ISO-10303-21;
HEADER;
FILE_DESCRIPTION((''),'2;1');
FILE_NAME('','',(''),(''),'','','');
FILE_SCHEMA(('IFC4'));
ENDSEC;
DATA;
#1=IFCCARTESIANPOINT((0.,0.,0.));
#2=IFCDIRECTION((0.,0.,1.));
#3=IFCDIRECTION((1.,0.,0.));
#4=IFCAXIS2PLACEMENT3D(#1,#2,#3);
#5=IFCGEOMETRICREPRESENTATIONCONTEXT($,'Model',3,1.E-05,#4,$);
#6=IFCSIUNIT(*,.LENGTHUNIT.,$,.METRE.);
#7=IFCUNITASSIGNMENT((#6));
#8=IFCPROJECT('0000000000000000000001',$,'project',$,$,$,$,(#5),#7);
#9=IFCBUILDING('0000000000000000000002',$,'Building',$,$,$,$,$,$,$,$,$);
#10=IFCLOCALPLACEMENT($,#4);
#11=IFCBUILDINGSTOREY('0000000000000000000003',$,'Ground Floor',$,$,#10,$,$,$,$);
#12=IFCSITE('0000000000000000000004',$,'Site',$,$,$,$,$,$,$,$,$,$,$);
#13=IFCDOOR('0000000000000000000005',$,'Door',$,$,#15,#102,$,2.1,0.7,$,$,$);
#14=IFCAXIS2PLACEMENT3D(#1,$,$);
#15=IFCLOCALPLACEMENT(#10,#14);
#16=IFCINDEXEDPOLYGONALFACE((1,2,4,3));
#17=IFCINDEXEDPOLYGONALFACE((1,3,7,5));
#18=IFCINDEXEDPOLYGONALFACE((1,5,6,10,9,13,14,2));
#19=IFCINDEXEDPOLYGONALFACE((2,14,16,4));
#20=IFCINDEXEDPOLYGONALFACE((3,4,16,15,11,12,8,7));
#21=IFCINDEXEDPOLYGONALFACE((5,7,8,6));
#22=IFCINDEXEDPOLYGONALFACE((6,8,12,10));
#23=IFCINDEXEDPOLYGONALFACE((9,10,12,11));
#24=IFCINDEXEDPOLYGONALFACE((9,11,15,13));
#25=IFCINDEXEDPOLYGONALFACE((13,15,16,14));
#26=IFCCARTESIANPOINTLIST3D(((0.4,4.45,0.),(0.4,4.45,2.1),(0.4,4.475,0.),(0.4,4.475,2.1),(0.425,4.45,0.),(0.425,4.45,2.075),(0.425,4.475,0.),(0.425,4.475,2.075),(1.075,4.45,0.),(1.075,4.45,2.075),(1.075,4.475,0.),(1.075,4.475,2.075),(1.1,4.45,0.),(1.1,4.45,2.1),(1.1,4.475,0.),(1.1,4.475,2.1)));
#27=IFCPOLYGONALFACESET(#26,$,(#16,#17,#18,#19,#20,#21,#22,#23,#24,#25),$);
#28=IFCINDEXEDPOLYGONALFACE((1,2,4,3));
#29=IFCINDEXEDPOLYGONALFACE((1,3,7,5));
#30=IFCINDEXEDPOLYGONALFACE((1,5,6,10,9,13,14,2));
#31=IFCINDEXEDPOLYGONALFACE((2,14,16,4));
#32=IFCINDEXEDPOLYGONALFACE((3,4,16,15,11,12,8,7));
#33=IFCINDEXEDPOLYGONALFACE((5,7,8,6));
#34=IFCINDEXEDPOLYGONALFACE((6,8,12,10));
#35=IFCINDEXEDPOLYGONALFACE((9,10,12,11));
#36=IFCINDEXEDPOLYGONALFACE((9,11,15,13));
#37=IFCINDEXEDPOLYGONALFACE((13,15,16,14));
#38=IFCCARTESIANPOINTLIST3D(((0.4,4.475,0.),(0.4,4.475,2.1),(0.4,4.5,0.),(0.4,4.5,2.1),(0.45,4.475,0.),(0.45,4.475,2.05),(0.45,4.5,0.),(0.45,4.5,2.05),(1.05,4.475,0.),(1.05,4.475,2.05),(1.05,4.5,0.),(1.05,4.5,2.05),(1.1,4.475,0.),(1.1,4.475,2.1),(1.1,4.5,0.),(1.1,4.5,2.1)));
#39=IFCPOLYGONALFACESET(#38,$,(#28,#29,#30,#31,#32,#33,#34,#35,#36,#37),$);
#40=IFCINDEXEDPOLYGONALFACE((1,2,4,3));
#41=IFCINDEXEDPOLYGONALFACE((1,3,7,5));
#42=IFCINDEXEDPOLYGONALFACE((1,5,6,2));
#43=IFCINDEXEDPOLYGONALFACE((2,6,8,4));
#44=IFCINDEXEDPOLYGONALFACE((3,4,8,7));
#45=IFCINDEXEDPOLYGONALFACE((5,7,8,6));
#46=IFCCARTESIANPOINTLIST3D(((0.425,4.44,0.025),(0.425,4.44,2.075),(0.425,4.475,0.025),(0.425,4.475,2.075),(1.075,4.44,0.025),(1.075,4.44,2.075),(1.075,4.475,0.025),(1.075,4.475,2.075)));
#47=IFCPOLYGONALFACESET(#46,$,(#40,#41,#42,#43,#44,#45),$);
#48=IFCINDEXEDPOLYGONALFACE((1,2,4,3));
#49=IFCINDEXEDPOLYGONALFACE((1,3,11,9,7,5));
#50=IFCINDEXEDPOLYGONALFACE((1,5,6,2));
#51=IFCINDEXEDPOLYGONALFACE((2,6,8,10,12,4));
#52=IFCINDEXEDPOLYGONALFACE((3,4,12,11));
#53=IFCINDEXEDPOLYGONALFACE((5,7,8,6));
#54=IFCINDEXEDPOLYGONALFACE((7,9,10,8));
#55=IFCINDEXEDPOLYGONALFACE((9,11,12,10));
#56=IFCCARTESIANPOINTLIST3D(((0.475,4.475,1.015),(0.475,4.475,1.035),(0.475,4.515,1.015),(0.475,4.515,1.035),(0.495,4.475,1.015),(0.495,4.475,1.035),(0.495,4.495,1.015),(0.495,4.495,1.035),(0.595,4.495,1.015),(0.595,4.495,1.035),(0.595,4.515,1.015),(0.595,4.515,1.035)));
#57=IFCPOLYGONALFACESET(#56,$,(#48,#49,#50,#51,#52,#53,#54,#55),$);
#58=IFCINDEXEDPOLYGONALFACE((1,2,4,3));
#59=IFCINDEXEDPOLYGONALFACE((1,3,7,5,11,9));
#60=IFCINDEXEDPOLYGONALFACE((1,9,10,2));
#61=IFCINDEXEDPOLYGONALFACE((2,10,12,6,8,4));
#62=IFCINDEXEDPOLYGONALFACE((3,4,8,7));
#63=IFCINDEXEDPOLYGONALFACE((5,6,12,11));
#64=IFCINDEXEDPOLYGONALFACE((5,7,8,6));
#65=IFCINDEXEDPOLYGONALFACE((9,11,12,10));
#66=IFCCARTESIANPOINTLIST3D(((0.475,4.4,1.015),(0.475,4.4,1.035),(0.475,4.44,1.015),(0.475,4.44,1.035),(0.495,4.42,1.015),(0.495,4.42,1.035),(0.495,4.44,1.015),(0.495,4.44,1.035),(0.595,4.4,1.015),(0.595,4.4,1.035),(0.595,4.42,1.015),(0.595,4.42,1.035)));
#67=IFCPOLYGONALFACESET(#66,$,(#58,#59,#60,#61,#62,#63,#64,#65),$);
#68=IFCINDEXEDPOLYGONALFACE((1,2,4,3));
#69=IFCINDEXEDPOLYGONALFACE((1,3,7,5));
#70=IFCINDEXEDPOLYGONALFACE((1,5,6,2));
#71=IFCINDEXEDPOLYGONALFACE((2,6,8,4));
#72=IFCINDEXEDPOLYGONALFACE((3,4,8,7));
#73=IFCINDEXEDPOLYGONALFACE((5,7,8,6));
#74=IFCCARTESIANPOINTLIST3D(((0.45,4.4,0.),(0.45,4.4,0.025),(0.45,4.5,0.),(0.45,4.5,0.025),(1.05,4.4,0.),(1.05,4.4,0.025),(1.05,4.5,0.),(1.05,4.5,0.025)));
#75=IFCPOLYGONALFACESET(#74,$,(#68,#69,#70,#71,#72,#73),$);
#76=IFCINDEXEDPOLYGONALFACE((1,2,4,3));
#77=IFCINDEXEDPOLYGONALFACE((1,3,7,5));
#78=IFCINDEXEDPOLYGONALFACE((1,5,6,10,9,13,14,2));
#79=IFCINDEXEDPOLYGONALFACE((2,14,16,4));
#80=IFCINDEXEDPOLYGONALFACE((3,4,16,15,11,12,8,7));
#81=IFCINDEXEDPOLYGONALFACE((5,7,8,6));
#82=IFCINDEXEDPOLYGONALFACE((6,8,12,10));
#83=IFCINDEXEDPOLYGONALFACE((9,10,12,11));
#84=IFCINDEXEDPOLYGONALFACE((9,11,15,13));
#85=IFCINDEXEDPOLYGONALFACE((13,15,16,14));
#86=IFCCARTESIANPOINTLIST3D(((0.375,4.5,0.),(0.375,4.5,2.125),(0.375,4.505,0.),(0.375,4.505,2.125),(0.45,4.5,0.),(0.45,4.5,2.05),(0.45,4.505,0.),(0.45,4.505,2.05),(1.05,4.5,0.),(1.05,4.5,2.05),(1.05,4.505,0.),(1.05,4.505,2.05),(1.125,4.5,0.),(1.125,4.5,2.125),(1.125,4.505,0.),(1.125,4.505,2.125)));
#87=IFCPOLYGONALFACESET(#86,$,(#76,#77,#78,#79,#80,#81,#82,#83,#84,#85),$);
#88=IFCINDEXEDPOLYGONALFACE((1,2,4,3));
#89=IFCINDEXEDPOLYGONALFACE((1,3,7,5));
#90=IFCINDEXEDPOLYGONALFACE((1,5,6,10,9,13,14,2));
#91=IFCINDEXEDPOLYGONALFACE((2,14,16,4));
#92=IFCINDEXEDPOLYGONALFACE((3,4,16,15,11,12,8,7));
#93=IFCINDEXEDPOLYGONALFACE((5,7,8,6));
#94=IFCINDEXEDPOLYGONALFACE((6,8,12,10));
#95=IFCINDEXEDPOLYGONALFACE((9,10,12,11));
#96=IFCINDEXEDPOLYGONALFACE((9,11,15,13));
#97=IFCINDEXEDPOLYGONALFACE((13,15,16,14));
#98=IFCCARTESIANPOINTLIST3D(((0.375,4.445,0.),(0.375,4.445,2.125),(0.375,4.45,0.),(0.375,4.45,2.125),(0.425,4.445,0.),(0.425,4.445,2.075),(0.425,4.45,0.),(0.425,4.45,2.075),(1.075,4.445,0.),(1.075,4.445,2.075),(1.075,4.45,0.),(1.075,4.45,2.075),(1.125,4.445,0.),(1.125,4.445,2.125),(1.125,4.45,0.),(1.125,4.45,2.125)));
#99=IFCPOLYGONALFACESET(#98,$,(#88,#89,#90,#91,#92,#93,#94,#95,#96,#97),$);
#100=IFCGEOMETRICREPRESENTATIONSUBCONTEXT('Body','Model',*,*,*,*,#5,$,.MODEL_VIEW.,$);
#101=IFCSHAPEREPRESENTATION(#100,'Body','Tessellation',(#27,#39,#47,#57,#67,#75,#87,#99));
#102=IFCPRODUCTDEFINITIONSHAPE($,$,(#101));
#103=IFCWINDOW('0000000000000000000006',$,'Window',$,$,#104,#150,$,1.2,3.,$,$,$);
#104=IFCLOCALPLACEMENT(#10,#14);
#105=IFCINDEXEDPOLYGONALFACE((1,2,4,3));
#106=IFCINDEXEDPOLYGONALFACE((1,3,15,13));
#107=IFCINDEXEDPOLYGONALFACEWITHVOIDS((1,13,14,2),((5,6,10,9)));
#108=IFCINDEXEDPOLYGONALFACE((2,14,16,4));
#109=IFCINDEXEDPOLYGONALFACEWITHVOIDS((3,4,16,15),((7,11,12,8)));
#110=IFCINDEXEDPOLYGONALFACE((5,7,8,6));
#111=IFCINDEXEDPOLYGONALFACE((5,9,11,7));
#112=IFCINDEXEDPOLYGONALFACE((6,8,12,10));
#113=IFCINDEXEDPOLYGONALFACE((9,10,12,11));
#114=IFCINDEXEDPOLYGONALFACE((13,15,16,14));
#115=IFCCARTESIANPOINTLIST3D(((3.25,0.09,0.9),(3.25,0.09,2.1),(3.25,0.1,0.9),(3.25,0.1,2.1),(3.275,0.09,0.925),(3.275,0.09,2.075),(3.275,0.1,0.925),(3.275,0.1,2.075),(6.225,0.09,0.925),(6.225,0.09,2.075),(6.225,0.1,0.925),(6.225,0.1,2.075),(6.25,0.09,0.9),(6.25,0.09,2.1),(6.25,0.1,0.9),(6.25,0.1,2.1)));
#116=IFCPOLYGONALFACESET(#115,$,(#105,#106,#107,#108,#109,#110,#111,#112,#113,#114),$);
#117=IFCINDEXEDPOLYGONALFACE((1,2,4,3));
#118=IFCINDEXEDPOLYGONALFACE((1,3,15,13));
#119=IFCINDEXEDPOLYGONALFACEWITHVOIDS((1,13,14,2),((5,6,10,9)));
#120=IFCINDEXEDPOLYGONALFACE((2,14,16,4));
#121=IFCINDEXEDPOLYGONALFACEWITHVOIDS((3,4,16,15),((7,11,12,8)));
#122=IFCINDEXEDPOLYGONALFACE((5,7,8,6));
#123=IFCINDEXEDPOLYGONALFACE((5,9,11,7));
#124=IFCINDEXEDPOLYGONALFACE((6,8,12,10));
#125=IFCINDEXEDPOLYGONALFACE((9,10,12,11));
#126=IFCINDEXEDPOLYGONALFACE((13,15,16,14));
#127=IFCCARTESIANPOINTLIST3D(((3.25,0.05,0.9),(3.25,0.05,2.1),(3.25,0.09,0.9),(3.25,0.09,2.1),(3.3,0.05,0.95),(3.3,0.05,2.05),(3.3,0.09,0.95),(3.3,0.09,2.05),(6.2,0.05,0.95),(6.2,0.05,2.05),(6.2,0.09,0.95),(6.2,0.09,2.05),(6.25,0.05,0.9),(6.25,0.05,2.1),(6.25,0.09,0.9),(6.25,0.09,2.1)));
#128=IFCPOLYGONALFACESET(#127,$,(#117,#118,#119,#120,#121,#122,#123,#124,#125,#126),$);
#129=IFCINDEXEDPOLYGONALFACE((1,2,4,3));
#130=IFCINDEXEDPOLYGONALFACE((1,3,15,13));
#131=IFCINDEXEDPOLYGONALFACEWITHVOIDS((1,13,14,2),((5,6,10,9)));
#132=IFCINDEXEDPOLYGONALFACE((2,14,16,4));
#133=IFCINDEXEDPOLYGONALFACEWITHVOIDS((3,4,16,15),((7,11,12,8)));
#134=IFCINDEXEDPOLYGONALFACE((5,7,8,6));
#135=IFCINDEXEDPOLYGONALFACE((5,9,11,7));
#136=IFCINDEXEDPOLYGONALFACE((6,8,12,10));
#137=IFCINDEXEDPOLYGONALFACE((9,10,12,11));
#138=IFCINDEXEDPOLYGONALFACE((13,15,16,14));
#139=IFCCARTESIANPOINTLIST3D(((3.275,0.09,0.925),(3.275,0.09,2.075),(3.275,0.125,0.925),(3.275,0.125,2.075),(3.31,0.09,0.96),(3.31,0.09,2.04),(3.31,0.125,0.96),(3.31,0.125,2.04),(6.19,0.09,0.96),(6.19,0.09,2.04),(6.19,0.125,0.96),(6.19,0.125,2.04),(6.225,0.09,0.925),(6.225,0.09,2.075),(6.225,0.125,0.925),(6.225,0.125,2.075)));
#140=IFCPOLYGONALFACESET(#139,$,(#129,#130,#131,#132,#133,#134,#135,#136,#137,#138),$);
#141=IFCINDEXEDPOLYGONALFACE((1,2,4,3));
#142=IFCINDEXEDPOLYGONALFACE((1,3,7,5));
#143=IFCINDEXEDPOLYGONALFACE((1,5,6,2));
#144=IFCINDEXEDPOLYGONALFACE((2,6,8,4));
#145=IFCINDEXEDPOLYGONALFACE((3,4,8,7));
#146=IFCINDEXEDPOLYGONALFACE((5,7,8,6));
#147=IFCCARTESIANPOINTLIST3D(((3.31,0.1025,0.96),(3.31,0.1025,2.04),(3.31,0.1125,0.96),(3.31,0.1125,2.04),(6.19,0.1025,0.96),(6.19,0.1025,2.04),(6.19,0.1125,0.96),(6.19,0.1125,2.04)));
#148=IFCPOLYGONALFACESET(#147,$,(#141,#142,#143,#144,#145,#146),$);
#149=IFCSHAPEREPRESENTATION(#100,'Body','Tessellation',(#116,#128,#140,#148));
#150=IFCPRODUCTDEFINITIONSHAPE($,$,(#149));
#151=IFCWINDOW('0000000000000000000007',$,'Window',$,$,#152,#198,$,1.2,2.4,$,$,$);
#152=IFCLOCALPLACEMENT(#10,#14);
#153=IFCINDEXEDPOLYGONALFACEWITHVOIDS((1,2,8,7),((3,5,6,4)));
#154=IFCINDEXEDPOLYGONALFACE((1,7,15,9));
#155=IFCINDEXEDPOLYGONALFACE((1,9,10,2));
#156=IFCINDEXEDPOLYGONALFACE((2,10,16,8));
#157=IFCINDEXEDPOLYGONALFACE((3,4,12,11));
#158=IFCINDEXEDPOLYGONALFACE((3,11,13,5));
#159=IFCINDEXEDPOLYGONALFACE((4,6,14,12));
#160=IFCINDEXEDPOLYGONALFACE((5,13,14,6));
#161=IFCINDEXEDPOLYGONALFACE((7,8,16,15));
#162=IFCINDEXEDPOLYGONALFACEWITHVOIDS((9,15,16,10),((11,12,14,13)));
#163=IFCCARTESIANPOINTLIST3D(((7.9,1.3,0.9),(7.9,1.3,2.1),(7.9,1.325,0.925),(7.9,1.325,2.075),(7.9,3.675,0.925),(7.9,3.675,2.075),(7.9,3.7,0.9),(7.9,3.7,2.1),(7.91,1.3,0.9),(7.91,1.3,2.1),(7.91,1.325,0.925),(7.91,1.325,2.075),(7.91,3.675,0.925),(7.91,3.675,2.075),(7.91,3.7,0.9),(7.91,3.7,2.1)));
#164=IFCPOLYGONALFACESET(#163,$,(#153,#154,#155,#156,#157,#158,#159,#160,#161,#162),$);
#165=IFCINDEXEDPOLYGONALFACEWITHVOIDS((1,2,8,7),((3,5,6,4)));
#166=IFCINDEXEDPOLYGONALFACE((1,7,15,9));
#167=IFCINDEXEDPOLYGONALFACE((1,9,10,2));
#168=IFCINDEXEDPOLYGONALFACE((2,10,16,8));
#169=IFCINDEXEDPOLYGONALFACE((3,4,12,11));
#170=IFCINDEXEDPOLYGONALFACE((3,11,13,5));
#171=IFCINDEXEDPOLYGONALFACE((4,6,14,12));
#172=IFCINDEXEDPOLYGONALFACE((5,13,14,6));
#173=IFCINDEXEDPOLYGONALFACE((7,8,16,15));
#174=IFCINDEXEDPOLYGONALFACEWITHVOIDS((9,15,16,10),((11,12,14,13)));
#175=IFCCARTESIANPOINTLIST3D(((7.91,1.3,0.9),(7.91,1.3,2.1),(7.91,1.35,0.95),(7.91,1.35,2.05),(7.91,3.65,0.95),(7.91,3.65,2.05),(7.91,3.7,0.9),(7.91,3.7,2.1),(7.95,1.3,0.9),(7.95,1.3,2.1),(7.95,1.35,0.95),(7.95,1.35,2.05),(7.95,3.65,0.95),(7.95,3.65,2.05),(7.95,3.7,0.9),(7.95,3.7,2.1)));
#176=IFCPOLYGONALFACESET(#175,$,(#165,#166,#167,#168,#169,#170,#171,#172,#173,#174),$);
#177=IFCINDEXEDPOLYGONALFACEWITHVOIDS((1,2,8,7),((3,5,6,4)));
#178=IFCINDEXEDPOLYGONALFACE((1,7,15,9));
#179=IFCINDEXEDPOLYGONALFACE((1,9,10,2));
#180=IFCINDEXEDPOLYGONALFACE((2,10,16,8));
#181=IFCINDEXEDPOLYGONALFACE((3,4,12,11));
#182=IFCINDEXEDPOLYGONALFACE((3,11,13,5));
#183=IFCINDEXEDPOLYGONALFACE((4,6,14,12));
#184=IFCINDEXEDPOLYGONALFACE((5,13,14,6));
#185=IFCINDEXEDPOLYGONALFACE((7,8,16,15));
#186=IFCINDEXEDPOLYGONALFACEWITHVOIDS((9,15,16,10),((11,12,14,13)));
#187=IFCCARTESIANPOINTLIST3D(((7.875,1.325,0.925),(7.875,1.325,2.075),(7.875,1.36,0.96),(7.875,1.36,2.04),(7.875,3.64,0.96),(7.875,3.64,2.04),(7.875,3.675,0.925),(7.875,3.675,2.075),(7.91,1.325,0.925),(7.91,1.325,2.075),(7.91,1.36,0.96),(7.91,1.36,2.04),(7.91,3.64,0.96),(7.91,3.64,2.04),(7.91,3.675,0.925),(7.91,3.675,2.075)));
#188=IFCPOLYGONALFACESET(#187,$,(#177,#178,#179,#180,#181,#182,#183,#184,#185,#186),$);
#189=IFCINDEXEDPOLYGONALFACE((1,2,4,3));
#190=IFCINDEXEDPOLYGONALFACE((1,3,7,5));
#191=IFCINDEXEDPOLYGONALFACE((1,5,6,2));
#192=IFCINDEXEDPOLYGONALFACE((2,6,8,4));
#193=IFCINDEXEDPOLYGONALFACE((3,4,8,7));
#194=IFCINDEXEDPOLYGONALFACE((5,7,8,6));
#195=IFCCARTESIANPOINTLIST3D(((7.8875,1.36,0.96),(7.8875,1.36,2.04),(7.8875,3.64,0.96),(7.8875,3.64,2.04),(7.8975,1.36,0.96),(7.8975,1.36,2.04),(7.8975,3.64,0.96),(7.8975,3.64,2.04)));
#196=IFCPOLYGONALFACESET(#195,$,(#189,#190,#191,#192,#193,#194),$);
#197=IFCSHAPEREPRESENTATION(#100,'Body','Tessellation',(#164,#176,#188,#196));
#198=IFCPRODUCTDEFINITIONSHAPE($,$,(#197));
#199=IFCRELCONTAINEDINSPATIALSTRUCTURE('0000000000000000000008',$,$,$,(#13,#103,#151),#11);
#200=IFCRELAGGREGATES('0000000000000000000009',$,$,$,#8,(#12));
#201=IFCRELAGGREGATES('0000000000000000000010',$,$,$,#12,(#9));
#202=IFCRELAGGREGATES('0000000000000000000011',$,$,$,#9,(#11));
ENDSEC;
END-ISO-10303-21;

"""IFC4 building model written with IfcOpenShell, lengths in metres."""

from ifc_helpers import new_model, si_unit, frame, origin_with_axes, place, context, subcontext, project, spatial, line, indexed_curve, outline, extrude, element, save


model = new_model("IFC4")

# Units and contexts
model_context = context("Model", 3, precision=1e-05, world=origin_with_axes())
body_context = subcontext(model_context, "Body", "Model", "MODEL_VIEW")
ifc_project = project(units=[si_unit("LENGTHUNIT", "METRE")], contexts=[model_context])

# Site, building, storey
site = spatial("IfcSite", under=ifc_project, Name="Site")
building = spatial("IfcBuilding", under=site, Name="Building")
storey_placement = place(None, origin_with_axes())
storey = spatial("IfcBuildingStorey", under=building, at=storey_placement, Name="Ground Floor")

# Door
door_1_placement = place(storey_placement, frame((1.1, 4.5, 0.0), z_axis=(0.0, 0.0, 1.0), x_axis=(-1.0, 0.0, 0.0)))
element("IfcDoor", 1, at=door_1_placement, inside=storey, Name="Door", OverallHeight=2.1, OverallWidth=0.7, context=body_context, shape_type="SweptSolid", body=[
    extrude(outline(indexed_curve([(0.0, 0.0), (0.0, 2.1), (0.7, 2.1), (0.7, 0.0), (0.675, 0.0), (0.675, 2.075), (0.025, 2.075), (0.025, 0.0)], segments=[line(1, 2, 3, 4, 5, 6, 7, 8, 1)])), frame((0.0, 0.025, 0.0), z_axis=(0.0, -1.0, 0.0), x_axis=(1.0, 0.0, 0.0)), (0.0, 0.0, -1.0), 0.025),
    extrude(outline(indexed_curve([(0.0, 0.0), (0.0, 2.1), (0.7, 2.1), (0.7, 0.0), (0.65, 0.0), (0.65, 2.05), (0.05, 2.05), (0.05, 0.0)], segments=[line(1, 2, 3, 4, 5, 6, 7, 8, 1)])), frame((0.0, 0.0, 0.0), z_axis=(0.0, -1.0, 0.0), x_axis=(1.0, 0.0, 0.0)), (0.0, 0.0, -1.0), 0.025),
    extrude(outline(indexed_curve([(0.0, 0.0), (0.65, 0.0), (0.65, 0.035), (0.0, 0.035)], segments=[line(1, 2, 3, 4, 1)])), frame((0.025, 0.025, 0.025), z_axis=(0.0, 0.0, 1.0), x_axis=(1.0, 0.0, 0.0)), (0.0, 0.0, 1.0), 2.05),
    extrude(outline(indexed_curve([(0.0, 0.0), (0.0, -0.04), (-0.12, -0.04), (-0.12, -0.02), (-0.02, -0.02), (-0.02, 0.0)], segments=[line(1, 2, 3, 4, 5, 6, 1)])), frame((0.625, 0.025, 1.015), z_axis=(0.0, 0.0, 1.0), x_axis=(1.0, 0.0, 0.0)), (0.0, 0.0, 1.0), 0.02),
    extrude(outline(indexed_curve([(0.0, 0.0), (0.0, 0.04), (-0.12, 0.04), (-0.12, 0.02), (-0.02, 0.02), (-0.02, 0.0)], segments=[line(1, 2, 3, 4, 5, 6, 1)])), frame((0.625, 0.06, 1.015), z_axis=(0.0, 0.0, 1.0), x_axis=(1.0, 0.0, 0.0)), (0.0, 0.0, 1.0), 0.02),
    extrude(outline(indexed_curve([(0.0, 0.0), (0.6, 0.0), (0.6, 0.1), (0.0, 0.1)], segments=[line(1, 2, 3, 4, 1)])), frame((0.05, 0.0, 0.0), z_axis=(0.0, 0.0, 1.0), x_axis=(1.0, 0.0, 0.0)), (0.0, 0.0, 1.0), 0.025),
    extrude(outline(indexed_curve([(0.0, 0.0), (0.0, 2.125), (0.75, 2.125), (0.75, 0.0), (0.675, 0.0), (0.675, 2.05), (0.075, 2.05), (0.075, 0.0)], segments=[line(1, 2, 3, 4, 5, 6, 7, 8, 1)])), frame((-0.025, -0.005, 0.0), z_axis=(0.0, -1.0, 0.0), x_axis=(1.0, 0.0, 0.0)), (0.0, 0.0, -1.0), 0.005),
    extrude(outline(indexed_curve([(0.0, 0.0), (0.0, 2.125), (0.75, 2.125), (0.75, 0.0), (0.7, 0.0), (0.7, 2.075), (0.05, 2.075), (0.05, 0.0)], segments=[line(1, 2, 3, 4, 5, 6, 7, 8, 1)])), frame((-0.025, 0.05, 0.0), z_axis=(0.0, -1.0, 0.0), x_axis=(1.0, 0.0, 0.0)), (0.0, 0.0, -1.0), 0.005),
])

# Windows
window_1_placement = place(storey_placement, frame((3.25, 0.0, 0.9), z_axis=(0.0, 0.0, 1.0), x_axis=(1.0, 0.0, 0.0)))
element("IfcWindow", 2, at=window_1_placement, inside=storey, Name="Window", OverallHeight=1.2, OverallWidth=3.0, context=body_context, shape_type="SweptSolid", body=[
    extrude(outline(indexed_curve([(0.0, 0.0), (3.0, 0.0), (3.0, 1.2), (0.0, 1.2)], segments=[line(1, 2, 3, 4, 1)]), holes=[indexed_curve([(0.025, 0.025), (2.975, 0.025), (2.975, 1.175), (0.025, 1.175)], segments=[line(1, 2, 3, 4, 1)])]), frame((0.0, 0.09, 0.0), z_axis=(0.0, -1.0, 0.0), x_axis=(1.0, 0.0, 0.0)), (0.0, 0.0, -1.0), 0.01),
    extrude(outline(indexed_curve([(0.0, 0.0), (3.0, 0.0), (3.0, 1.2), (0.0, 1.2)], segments=[line(1, 2, 3, 4, 1)]), holes=[indexed_curve([(0.05, 0.05), (2.95, 0.05), (2.95, 1.15), (0.05, 1.15)], segments=[line(1, 2, 3, 4, 1)])]), frame((0.0, 0.05, 0.0), z_axis=(0.0, -1.0, 0.0), x_axis=(1.0, 0.0, 0.0)), (0.0, 0.0, -1.0), 0.04),
    extrude(outline(indexed_curve([(0.0, 0.0), (2.95, 0.0), (2.95, 1.15), (0.0, 1.15)], segments=[line(1, 2, 3, 4, 1)]), holes=[indexed_curve([(0.035, 0.035), (2.915, 0.035), (2.915, 1.115), (0.035, 1.115)], segments=[line(1, 2, 3, 4, 1)])]), frame((0.025, 0.09, 0.025), z_axis=(0.0, -1.0, 0.0), x_axis=(1.0, 0.0, 0.0)), (0.0, 0.0, -1.0), 0.035),
    extrude(outline(indexed_curve([(0.035, 0.035), (2.915, 0.035), (2.915, 1.115), (0.035, 1.115)], segments=[line(1, 2, 3, 4, 1)])), frame((0.025, 0.1025, 0.025), z_axis=(0.0, -1.0, 0.0), x_axis=(1.0, 0.0, 0.0)), (0.0, 0.0, -1.0), 0.01),
])
window_2_placement = place(storey_placement, frame((8.0, 1.3, 0.9), z_axis=(0.0, 0.0, 1.0), x_axis=(0.0, 1.0, 0.0)))
element("IfcWindow", 3, at=window_2_placement, inside=storey, Name="Window", OverallHeight=1.2, OverallWidth=2.4, context=body_context, shape_type="SweptSolid", body=[
    extrude(outline(indexed_curve([(0.0, 0.0), (2.4, 0.0), (2.4, 1.2), (0.0, 1.2)], segments=[line(1, 2, 3, 4, 1)]), holes=[indexed_curve([(0.025, 0.025), (2.375, 0.025), (2.375, 1.175), (0.025, 1.175)], segments=[line(1, 2, 3, 4, 1)])]), frame((0.0, 0.09, 0.0), z_axis=(0.0, -1.0, 0.0), x_axis=(1.0, 0.0, 0.0)), (0.0, 0.0, -1.0), 0.01),
    extrude(outline(indexed_curve([(0.0, 0.0), (2.4, 0.0), (2.4, 1.2), (0.0, 1.2)], segments=[line(1, 2, 3, 4, 1)]), holes=[indexed_curve([(0.05, 0.05), (2.35, 0.05), (2.35, 1.15), (0.05, 1.15)], segments=[line(1, 2, 3, 4, 1)])]), frame((0.0, 0.05, 0.0), z_axis=(0.0, -1.0, 0.0), x_axis=(1.0, 0.0, 0.0)), (0.0, 0.0, -1.0), 0.04),
    extrude(outline(indexed_curve([(0.0, 0.0), (2.35, 0.0), (2.35, 1.15), (0.0, 1.15)], segments=[line(1, 2, 3, 4, 1)]), holes=[indexed_curve([(0.035, 0.035), (2.315, 0.035), (2.315, 1.115), (0.035, 1.115)], segments=[line(1, 2, 3, 4, 1)])]), frame((0.025, 0.09, 0.025), z_axis=(0.0, -1.0, 0.0), x_axis=(1.0, 0.0, 0.0)), (0.0, 0.0, -1.0), 0.035),
    extrude(outline(indexed_curve([(0.035, 0.035), (2.315, 0.035), (2.315, 1.115), (0.035, 1.115)], segments=[line(1, 2, 3, 4, 1)])), frame((0.025, 0.1025, 0.025), z_axis=(0.0, -1.0, 0.0), x_axis=(1.0, 0.0, 0.0)), (0.0, 0.0, -1.0), 0.01),
])

save(model, "model.ifc")
